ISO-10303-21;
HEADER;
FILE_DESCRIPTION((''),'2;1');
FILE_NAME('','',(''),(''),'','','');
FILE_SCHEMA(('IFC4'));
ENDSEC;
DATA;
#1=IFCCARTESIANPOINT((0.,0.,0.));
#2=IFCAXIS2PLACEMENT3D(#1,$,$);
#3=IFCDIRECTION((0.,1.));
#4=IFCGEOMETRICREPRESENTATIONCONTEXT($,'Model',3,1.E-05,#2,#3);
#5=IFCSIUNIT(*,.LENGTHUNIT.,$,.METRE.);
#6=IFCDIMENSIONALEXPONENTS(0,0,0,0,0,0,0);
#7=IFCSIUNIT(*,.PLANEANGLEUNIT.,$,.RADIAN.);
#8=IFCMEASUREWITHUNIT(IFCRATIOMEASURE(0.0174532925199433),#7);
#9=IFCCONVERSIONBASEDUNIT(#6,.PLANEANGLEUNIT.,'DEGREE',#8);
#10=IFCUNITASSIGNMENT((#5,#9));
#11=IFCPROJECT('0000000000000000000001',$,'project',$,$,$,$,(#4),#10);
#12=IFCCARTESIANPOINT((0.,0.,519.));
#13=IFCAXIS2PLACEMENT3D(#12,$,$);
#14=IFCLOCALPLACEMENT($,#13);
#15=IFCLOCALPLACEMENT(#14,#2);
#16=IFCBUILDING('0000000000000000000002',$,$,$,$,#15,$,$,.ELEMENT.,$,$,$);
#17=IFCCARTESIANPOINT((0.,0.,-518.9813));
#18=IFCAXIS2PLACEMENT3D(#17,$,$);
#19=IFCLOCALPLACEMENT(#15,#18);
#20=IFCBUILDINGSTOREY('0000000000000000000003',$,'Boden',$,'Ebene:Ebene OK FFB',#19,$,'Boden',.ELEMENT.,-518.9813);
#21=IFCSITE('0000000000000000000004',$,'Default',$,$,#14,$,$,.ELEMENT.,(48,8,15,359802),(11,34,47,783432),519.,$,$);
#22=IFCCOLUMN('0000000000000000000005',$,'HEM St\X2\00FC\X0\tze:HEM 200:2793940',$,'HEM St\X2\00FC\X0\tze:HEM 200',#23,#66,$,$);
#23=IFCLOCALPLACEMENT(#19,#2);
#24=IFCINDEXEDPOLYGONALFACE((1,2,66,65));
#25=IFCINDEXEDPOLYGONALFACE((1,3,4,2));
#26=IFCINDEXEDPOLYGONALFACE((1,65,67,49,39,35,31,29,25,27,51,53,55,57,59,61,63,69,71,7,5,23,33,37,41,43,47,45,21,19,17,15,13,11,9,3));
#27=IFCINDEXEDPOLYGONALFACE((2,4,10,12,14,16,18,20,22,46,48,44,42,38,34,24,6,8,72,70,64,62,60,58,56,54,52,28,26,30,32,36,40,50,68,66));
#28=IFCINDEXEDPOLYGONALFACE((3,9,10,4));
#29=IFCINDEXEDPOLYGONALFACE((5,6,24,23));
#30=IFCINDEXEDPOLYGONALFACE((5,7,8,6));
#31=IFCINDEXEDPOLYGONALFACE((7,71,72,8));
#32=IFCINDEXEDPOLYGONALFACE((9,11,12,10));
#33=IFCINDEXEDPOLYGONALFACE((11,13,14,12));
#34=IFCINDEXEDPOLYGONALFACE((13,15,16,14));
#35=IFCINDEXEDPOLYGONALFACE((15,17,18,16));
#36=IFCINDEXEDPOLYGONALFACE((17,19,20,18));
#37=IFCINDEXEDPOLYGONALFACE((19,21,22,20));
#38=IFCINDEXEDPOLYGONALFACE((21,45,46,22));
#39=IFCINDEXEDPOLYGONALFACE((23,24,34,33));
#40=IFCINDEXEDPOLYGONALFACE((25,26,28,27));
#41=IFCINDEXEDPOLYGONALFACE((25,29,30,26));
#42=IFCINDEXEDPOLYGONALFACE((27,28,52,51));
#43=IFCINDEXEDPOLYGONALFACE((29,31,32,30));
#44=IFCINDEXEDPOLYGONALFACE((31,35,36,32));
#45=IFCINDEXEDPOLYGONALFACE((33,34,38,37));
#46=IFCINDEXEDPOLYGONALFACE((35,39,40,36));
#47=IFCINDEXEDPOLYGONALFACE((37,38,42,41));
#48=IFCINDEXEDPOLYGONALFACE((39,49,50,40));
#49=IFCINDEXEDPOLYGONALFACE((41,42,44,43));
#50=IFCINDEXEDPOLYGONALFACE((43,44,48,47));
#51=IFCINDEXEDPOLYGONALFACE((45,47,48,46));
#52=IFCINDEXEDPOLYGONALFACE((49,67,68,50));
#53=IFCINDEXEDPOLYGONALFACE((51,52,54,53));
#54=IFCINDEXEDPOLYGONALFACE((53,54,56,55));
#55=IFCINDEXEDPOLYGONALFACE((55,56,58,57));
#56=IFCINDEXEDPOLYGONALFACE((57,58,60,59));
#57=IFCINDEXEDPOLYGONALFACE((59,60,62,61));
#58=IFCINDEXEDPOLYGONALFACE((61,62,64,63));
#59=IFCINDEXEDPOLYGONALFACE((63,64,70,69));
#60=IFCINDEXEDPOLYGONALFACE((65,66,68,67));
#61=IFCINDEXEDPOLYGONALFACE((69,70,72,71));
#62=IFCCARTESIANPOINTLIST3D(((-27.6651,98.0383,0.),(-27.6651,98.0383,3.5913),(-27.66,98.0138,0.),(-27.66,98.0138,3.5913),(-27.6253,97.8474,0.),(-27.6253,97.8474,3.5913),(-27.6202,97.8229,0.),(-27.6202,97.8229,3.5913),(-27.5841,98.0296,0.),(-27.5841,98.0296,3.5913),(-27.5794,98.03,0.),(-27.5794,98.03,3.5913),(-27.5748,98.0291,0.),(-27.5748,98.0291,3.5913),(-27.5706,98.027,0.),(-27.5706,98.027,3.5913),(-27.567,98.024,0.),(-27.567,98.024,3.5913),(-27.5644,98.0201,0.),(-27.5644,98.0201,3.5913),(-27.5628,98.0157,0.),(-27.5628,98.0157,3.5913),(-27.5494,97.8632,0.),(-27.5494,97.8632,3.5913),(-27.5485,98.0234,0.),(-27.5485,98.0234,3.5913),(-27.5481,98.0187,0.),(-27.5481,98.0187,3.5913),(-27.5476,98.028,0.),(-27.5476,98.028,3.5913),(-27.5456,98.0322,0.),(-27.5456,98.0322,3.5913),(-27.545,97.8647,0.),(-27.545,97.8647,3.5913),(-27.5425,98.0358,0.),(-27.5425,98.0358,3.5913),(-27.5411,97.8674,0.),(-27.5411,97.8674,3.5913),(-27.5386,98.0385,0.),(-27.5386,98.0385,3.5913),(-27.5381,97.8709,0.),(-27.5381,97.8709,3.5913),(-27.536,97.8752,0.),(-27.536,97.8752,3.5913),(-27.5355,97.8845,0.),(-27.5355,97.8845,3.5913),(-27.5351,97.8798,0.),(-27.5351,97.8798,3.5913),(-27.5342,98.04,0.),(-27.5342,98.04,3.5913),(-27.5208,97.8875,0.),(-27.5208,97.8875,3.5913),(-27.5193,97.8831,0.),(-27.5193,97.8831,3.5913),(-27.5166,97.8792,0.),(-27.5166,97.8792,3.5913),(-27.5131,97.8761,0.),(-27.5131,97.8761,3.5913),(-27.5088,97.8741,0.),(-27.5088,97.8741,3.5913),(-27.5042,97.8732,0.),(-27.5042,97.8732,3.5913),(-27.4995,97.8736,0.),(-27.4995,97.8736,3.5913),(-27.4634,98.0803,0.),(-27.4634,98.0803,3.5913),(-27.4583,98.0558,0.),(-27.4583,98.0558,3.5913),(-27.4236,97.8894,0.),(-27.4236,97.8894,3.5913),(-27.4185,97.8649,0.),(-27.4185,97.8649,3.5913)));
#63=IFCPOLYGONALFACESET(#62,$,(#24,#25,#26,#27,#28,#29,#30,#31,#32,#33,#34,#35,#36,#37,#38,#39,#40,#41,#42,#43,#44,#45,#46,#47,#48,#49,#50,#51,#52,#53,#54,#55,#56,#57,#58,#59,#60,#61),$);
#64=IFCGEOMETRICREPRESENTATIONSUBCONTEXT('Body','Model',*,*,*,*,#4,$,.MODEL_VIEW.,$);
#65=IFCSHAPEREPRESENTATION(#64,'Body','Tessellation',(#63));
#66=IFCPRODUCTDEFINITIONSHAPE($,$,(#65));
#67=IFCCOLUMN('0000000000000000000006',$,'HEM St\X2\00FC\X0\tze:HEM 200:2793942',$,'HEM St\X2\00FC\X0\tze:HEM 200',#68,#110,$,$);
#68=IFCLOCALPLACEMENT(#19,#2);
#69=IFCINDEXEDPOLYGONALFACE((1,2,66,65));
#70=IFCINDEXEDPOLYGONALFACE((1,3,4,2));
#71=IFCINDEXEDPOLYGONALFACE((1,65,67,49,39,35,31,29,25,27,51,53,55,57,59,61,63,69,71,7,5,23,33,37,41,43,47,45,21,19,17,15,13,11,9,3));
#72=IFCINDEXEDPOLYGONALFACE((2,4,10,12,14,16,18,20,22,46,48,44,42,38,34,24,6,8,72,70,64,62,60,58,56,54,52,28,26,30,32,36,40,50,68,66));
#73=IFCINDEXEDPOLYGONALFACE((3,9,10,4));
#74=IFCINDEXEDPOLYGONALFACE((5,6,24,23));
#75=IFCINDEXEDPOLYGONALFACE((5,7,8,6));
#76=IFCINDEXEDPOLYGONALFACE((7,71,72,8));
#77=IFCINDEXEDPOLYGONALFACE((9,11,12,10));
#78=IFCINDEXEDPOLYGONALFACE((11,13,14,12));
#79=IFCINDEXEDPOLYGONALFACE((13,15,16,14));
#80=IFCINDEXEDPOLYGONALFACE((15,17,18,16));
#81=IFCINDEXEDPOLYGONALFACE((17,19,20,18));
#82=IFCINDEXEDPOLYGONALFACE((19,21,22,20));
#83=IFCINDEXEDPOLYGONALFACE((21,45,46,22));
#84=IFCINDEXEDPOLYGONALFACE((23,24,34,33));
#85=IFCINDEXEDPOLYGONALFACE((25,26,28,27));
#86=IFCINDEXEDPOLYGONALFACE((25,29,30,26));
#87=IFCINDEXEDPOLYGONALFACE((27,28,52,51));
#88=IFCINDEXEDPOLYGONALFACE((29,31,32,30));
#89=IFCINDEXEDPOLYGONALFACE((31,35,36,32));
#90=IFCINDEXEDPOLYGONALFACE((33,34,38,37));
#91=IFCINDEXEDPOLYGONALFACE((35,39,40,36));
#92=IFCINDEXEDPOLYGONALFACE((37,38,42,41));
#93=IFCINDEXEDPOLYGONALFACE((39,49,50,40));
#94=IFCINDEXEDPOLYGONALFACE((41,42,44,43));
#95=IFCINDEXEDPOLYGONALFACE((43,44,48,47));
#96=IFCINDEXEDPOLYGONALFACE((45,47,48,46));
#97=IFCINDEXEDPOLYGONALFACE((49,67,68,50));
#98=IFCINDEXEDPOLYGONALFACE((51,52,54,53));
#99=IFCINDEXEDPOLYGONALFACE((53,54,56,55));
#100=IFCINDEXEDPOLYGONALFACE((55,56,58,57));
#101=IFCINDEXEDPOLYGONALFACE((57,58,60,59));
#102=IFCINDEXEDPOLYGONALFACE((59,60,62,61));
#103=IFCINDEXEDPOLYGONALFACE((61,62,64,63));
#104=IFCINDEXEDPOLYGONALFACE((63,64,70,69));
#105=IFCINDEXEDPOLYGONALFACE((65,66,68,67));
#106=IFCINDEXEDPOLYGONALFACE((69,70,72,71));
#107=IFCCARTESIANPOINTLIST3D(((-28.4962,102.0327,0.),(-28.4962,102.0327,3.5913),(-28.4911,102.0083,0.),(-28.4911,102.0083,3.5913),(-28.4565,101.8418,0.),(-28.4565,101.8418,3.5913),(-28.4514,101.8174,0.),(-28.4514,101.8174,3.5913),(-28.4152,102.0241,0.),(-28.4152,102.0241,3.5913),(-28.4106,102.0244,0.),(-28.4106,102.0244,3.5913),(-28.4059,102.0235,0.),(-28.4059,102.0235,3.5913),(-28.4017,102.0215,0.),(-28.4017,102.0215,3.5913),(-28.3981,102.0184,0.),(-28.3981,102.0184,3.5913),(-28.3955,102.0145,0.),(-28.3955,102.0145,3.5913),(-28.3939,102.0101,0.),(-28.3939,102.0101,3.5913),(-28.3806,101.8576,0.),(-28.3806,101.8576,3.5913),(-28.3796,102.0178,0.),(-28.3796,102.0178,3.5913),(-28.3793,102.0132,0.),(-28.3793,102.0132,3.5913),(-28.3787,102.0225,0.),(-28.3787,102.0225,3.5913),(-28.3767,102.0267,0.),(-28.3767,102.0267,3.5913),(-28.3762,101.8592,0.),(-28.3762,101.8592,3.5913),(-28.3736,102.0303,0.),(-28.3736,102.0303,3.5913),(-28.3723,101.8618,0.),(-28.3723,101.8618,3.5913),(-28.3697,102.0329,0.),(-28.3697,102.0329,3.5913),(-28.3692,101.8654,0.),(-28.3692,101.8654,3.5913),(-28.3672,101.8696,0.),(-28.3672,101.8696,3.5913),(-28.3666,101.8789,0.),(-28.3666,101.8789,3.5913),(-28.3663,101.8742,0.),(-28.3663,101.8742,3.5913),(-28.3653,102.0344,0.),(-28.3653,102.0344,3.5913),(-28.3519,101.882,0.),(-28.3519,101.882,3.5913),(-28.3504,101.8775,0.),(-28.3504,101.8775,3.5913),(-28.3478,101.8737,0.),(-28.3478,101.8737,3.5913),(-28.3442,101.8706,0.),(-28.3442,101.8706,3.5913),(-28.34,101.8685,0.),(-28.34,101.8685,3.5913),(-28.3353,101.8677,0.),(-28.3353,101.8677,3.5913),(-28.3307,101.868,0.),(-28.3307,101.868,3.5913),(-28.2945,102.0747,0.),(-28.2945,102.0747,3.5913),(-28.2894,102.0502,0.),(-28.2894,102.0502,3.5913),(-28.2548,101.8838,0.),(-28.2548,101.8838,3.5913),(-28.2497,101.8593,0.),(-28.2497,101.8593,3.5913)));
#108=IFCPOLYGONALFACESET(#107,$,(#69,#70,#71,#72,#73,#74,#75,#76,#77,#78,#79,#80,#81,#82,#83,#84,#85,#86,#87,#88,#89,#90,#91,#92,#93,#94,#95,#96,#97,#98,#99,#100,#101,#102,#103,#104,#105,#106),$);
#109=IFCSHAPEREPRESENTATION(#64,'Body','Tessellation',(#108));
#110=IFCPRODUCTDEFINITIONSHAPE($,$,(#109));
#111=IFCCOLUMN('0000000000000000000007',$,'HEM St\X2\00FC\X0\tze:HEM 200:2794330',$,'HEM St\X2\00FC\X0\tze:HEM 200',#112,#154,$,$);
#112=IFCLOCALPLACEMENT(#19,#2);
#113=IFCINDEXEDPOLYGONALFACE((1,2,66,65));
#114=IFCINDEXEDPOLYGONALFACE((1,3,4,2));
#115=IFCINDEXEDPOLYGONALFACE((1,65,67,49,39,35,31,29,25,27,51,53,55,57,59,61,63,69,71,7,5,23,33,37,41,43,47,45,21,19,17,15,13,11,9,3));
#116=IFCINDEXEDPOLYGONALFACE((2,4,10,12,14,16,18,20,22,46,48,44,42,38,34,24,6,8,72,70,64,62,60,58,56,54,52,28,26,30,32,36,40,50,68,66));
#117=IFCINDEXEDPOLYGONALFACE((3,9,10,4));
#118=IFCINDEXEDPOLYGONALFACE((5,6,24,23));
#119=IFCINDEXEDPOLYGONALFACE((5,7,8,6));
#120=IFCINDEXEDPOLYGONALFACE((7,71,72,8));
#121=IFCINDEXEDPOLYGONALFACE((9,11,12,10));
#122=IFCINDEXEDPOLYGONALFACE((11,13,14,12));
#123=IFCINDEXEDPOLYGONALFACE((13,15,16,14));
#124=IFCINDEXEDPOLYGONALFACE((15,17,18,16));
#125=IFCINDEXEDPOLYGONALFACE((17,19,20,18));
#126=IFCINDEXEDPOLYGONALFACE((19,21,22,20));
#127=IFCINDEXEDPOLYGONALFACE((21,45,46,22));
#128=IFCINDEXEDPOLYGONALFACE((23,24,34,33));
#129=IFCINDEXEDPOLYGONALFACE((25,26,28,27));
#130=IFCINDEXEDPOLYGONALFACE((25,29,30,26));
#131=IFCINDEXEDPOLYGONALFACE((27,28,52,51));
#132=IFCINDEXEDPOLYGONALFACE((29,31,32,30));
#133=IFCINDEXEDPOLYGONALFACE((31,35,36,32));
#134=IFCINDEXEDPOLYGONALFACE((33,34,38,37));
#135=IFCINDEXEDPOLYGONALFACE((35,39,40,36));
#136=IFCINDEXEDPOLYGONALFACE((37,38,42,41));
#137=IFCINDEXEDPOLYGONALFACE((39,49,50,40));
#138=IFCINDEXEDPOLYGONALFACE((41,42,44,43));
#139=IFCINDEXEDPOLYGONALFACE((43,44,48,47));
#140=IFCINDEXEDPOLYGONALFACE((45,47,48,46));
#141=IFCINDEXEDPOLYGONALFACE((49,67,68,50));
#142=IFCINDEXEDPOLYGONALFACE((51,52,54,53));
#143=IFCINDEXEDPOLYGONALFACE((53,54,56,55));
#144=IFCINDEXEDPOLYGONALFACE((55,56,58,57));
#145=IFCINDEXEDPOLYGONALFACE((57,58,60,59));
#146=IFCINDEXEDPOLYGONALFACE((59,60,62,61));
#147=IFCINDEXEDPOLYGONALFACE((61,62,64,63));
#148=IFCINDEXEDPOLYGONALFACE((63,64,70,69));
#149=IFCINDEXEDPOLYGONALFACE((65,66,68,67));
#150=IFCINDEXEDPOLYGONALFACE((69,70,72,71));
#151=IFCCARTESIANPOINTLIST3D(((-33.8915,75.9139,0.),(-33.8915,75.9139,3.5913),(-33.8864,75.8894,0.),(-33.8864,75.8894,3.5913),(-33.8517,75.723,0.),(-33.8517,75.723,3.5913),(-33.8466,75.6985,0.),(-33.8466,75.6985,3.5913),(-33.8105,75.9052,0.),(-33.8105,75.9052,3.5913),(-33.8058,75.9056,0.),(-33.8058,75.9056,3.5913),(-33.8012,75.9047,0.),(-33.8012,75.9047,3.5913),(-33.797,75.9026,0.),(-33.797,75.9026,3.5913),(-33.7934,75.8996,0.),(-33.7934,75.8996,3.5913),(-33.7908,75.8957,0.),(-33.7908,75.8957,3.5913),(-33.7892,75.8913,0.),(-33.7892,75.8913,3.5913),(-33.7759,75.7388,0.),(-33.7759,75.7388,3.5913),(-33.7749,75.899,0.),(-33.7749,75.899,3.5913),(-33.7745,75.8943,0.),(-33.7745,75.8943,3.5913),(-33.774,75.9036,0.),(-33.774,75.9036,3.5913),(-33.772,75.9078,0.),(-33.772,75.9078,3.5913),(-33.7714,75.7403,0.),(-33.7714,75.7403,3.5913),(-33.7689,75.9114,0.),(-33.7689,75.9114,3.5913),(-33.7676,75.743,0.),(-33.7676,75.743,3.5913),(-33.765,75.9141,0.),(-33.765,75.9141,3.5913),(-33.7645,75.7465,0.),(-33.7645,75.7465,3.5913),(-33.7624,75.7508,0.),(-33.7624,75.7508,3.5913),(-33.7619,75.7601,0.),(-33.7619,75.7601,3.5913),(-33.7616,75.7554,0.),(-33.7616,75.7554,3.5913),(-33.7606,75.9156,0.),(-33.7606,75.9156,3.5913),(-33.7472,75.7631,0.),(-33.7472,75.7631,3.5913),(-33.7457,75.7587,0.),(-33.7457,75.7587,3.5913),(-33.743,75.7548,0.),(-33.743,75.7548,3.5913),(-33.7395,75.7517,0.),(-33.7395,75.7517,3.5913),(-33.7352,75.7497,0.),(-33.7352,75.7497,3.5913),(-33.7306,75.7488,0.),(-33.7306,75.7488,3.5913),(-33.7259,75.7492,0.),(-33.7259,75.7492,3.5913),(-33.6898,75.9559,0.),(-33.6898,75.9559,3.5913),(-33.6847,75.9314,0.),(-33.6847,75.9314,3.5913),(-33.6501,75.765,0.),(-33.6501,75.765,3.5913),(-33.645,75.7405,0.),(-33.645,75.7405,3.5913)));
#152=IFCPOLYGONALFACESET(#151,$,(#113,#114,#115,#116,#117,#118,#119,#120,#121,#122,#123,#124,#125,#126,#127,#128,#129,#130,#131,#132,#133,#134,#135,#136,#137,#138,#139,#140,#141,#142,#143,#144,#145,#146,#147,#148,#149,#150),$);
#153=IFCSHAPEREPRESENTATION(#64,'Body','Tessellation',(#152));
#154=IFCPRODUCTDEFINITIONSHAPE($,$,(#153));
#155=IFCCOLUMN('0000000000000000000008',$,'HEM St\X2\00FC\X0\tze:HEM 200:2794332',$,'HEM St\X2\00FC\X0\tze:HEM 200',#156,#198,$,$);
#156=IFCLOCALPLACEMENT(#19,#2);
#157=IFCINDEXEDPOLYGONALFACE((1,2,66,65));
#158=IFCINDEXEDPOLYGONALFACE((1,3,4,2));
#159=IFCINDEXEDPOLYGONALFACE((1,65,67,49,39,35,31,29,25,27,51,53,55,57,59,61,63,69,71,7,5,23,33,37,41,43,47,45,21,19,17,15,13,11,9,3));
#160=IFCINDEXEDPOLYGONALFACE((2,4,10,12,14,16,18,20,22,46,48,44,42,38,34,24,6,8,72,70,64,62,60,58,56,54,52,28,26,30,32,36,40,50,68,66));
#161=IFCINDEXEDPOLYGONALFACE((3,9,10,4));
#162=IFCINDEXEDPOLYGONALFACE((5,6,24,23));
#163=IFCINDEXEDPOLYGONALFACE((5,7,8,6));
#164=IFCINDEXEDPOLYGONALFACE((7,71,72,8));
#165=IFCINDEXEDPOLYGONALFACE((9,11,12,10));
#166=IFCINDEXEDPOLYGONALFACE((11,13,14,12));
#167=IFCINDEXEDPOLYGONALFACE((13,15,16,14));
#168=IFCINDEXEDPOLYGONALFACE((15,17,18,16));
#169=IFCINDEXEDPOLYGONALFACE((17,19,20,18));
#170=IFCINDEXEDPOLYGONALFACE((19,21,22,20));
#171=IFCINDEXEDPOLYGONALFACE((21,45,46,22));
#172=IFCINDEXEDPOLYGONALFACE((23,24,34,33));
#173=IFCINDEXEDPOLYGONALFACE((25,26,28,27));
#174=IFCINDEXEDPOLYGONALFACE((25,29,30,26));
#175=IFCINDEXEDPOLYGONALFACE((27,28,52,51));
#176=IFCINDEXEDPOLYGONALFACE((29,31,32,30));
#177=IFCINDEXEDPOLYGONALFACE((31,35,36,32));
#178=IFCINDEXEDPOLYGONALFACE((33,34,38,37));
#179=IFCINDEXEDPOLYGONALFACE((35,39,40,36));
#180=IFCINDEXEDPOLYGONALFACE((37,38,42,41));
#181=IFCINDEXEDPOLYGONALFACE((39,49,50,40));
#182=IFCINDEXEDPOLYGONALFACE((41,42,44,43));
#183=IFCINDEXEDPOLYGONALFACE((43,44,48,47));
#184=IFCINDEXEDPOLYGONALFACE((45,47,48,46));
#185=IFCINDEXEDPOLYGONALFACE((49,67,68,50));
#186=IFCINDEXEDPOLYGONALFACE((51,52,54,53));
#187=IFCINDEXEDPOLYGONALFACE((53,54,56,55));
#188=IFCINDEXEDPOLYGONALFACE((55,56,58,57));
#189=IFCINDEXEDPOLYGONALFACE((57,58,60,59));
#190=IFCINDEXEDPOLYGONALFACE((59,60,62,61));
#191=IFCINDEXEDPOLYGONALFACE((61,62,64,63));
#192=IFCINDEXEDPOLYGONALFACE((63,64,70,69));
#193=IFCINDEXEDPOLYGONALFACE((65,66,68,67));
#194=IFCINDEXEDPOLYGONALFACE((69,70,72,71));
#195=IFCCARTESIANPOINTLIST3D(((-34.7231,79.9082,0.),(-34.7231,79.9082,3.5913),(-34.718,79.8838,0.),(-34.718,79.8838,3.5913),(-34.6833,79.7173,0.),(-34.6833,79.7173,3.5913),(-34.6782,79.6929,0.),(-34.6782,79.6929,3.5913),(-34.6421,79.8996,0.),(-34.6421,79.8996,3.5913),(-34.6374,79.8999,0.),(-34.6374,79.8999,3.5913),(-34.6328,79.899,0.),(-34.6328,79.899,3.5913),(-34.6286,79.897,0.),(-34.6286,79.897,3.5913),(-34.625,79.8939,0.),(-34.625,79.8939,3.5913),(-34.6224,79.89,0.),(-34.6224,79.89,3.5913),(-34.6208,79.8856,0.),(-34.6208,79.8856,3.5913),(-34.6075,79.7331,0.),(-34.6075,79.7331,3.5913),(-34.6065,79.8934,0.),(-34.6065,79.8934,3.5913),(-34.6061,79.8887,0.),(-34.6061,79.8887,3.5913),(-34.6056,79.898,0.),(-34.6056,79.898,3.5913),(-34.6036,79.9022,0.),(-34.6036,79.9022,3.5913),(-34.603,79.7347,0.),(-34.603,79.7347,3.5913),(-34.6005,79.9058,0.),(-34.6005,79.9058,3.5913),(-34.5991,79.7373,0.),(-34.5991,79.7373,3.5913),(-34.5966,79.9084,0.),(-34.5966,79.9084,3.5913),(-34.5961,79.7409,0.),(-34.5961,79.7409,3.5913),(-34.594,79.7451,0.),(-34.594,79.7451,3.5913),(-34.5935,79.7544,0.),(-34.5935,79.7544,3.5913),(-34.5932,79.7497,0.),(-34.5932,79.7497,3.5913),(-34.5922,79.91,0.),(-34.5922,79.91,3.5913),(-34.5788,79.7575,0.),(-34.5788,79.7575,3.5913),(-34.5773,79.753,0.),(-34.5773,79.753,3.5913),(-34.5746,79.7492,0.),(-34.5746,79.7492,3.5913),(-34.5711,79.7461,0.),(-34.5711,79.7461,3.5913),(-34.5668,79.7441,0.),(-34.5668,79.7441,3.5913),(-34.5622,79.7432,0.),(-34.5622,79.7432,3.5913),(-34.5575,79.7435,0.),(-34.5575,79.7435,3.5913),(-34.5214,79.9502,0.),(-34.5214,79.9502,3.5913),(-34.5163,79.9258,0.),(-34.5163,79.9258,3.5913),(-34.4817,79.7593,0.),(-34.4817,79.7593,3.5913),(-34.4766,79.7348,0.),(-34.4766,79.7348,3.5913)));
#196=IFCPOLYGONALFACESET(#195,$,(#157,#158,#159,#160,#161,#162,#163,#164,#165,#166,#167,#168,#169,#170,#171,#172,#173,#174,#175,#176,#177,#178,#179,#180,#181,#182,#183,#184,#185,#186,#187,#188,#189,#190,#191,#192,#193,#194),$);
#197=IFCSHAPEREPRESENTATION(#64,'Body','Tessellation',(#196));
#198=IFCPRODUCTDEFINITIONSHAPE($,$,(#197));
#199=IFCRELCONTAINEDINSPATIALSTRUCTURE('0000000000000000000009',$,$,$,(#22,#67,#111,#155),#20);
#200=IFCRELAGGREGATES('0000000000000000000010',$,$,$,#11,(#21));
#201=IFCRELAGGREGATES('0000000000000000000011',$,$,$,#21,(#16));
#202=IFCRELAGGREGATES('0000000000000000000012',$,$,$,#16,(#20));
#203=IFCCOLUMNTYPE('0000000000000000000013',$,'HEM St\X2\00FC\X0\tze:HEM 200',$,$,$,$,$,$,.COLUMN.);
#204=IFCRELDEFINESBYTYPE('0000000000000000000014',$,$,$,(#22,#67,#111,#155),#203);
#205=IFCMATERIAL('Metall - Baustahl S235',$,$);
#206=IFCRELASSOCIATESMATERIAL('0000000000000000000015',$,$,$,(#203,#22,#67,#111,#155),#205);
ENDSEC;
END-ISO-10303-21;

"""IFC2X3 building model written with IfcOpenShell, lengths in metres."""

from ifc_helpers import new_model, entity, si_unit, converted_unit, direction, frame, frame_2d, origin, place, context, subcontext, project, spatial, polyline, circle_curve, parameter, trimmed, segment, composite_curve, outline, extrude, source, transform, mapped, material, type_object, type_shapes, element, save


model = new_model("IFC2X3")

# Units and contexts
model_context = context("Model", 3, precision=1e-05, world=origin(), true_north=direction((0.0, 1.0)))
body_context = subcontext(model_context, "Body", "Model", "MODEL_VIEW")
ifc_project = project(units=[si_unit("LENGTHUNIT", "METRE"), converted_unit("PLANEANGLEUNIT", "DEGREE", entity("IfcRatioMeasure", 0.0174532925199433), si_unit("PLANEANGLEUNIT", "RADIAN"), dimensions=[0, 0, 0, 0, 0, 0, 0])], contexts=[model_context])

# Site, building, storey
site_placement = place(None, frame((0.0, 0.0, 519.0)))
site = spatial("IfcSite", under=ifc_project, at=site_placement, Name="Default", CompositionType="ELEMENT", RefLatitude=(48, 8, 15, 359802), RefLongitude=(11, 34, 47, 783432), RefElevation=519.0)
building_placement = place(site_placement, origin())
building = spatial("IfcBuilding", under=site, at=building_placement, CompositionType="ELEMENT")
storey_placement = place(building_placement, frame((0.0, 0.0, -518.9813)))
storey = spatial("IfcBuildingStorey", under=building, at=storey_placement, Name="Boden", ObjectType="Ebene:Ebene OK FFB", LongName="Boden", CompositionType="ELEMENT", Elevation=-518.9813)

# Columns
ifc_material = material(Name="Metall - Baustahl S235")
column_type = type_object("IfcColumnType", Name="HEM Stütze:HEM 200", PredefinedType="COLUMN", material=ifc_material)
shared_shape = source(origin(), body_context, "Body", "SweptSolid", [
    extrude(outline(composite_curve([segment(polyline([(0.085, -0.103), (0.11, -0.103)]), True, "CONTINUOUS"), segment(polyline([(0.11, -0.103), (0.11, 0.103)]), True, "CONTINUOUS"), segment(polyline([(0.11, 0.103), (0.085, 0.103)]), True, "CONTINUOUS"), segment(polyline([(0.085, 0.103), (0.085, 0.0255)]), True, "CONTINUOUS"), segment(trimmed(circle_curve(frame_2d((0.067, 0.0255), x_axis=(1.0, 0.0)), 0.018), [parameter(270.0)], [parameter(0.0)], True, "PARAMETER"), False, "CONTINUOUS"), segment(polyline([(0.067, 0.0075), (-0.067, 0.0075)]), True, "CONTINUOUS"), segment(trimmed(circle_curve(frame_2d((-0.067, 0.0255), x_axis=(0.0, -1.0)), 0.018), [parameter(270.0)], [parameter(0.0)], True, "PARAMETER"), False, "CONTINUOUS"), segment(polyline([(-0.085, 0.0255), (-0.085, 0.103)]), True, "CONTINUOUS"), segment(polyline([(-0.085, 0.103), (-0.11, 0.103)]), True, "CONTINUOUS"), segment(polyline([(-0.11, 0.103), (-0.11, -0.103)]), True, "CONTINUOUS"), segment(polyline([(-0.11, -0.103), (-0.085, -0.103)]), True, "CONTINUOUS"), segment(polyline([(-0.085, -0.103), (-0.085, -0.0255)]), True, "CONTINUOUS"), segment(trimmed(circle_curve(frame_2d((-0.067, -0.0255), x_axis=(-1.0, 0.0)), 0.018), [parameter(270.0)], [parameter(0.0)], True, "PARAMETER"), False, "CONTINUOUS"), segment(polyline([(-0.067, -0.0075), (0.067, -0.0075)]), True, "CONTINUOUS"), segment(trimmed(circle_curve(frame_2d((0.067, -0.0255), x_axis=(0.0, 1.0)), 0.018), [parameter(270.0)], [parameter(0.0)], True, "PARAMETER"), False, "CONTINUOUS"), segment(polyline([(0.085, -0.0255), (0.085, -0.103)]), True, "CONTINUOUS")], self_intersect=False)), frame((0.0, 0.0, -518.9813), z_axis=(0.0, 0.0, 1.0), x_axis=(0.0, -1.0, 0.0)), (0.0, 0.0, 1.0), 3.5913),
])
type_shapes(column_type, [shared_shape])
for number, where, z_axis, x_axis, name in (
    (1, (-27.5418, 97.9516, 518.9813), (0.0, 0.0, 1.0), (0.979008, 0.20382, 0.0), "HEM Stütze:HEM 200:2793940"),
    (2, (-28.3729, 101.946, 518.9813), (0.0, 0.0, 1.0), (0.979008, 0.20382, 0.0), "HEM Stütze:HEM 200:2793942"),
    (3, (-33.7682, 75.8272, 518.9813), (0.0, 0.0, 1.0), (0.979008, 0.20382, 0.0), "HEM Stütze:HEM 200:2794330"),
    (4, (-34.5998, 79.8215, 518.9813), (0.0, 0.0, 1.0), (0.979008, 0.20382, 0.0), "HEM Stütze:HEM 200:2794332"),
):
    element("IfcColumn", number, at=place(storey_placement, frame(where, z_axis=z_axis, x_axis=x_axis)), inside=storey, type_object=column_type, material=ifc_material, Name=name, ObjectType="HEM Stütze:HEM 200", context=body_context, shape_type="MappedRepresentation", body=[
        mapped(shared_shape, transform((0.0, 0.0, 0.0), scale=1.0)),
    ])

save(model, "model.ifc")
